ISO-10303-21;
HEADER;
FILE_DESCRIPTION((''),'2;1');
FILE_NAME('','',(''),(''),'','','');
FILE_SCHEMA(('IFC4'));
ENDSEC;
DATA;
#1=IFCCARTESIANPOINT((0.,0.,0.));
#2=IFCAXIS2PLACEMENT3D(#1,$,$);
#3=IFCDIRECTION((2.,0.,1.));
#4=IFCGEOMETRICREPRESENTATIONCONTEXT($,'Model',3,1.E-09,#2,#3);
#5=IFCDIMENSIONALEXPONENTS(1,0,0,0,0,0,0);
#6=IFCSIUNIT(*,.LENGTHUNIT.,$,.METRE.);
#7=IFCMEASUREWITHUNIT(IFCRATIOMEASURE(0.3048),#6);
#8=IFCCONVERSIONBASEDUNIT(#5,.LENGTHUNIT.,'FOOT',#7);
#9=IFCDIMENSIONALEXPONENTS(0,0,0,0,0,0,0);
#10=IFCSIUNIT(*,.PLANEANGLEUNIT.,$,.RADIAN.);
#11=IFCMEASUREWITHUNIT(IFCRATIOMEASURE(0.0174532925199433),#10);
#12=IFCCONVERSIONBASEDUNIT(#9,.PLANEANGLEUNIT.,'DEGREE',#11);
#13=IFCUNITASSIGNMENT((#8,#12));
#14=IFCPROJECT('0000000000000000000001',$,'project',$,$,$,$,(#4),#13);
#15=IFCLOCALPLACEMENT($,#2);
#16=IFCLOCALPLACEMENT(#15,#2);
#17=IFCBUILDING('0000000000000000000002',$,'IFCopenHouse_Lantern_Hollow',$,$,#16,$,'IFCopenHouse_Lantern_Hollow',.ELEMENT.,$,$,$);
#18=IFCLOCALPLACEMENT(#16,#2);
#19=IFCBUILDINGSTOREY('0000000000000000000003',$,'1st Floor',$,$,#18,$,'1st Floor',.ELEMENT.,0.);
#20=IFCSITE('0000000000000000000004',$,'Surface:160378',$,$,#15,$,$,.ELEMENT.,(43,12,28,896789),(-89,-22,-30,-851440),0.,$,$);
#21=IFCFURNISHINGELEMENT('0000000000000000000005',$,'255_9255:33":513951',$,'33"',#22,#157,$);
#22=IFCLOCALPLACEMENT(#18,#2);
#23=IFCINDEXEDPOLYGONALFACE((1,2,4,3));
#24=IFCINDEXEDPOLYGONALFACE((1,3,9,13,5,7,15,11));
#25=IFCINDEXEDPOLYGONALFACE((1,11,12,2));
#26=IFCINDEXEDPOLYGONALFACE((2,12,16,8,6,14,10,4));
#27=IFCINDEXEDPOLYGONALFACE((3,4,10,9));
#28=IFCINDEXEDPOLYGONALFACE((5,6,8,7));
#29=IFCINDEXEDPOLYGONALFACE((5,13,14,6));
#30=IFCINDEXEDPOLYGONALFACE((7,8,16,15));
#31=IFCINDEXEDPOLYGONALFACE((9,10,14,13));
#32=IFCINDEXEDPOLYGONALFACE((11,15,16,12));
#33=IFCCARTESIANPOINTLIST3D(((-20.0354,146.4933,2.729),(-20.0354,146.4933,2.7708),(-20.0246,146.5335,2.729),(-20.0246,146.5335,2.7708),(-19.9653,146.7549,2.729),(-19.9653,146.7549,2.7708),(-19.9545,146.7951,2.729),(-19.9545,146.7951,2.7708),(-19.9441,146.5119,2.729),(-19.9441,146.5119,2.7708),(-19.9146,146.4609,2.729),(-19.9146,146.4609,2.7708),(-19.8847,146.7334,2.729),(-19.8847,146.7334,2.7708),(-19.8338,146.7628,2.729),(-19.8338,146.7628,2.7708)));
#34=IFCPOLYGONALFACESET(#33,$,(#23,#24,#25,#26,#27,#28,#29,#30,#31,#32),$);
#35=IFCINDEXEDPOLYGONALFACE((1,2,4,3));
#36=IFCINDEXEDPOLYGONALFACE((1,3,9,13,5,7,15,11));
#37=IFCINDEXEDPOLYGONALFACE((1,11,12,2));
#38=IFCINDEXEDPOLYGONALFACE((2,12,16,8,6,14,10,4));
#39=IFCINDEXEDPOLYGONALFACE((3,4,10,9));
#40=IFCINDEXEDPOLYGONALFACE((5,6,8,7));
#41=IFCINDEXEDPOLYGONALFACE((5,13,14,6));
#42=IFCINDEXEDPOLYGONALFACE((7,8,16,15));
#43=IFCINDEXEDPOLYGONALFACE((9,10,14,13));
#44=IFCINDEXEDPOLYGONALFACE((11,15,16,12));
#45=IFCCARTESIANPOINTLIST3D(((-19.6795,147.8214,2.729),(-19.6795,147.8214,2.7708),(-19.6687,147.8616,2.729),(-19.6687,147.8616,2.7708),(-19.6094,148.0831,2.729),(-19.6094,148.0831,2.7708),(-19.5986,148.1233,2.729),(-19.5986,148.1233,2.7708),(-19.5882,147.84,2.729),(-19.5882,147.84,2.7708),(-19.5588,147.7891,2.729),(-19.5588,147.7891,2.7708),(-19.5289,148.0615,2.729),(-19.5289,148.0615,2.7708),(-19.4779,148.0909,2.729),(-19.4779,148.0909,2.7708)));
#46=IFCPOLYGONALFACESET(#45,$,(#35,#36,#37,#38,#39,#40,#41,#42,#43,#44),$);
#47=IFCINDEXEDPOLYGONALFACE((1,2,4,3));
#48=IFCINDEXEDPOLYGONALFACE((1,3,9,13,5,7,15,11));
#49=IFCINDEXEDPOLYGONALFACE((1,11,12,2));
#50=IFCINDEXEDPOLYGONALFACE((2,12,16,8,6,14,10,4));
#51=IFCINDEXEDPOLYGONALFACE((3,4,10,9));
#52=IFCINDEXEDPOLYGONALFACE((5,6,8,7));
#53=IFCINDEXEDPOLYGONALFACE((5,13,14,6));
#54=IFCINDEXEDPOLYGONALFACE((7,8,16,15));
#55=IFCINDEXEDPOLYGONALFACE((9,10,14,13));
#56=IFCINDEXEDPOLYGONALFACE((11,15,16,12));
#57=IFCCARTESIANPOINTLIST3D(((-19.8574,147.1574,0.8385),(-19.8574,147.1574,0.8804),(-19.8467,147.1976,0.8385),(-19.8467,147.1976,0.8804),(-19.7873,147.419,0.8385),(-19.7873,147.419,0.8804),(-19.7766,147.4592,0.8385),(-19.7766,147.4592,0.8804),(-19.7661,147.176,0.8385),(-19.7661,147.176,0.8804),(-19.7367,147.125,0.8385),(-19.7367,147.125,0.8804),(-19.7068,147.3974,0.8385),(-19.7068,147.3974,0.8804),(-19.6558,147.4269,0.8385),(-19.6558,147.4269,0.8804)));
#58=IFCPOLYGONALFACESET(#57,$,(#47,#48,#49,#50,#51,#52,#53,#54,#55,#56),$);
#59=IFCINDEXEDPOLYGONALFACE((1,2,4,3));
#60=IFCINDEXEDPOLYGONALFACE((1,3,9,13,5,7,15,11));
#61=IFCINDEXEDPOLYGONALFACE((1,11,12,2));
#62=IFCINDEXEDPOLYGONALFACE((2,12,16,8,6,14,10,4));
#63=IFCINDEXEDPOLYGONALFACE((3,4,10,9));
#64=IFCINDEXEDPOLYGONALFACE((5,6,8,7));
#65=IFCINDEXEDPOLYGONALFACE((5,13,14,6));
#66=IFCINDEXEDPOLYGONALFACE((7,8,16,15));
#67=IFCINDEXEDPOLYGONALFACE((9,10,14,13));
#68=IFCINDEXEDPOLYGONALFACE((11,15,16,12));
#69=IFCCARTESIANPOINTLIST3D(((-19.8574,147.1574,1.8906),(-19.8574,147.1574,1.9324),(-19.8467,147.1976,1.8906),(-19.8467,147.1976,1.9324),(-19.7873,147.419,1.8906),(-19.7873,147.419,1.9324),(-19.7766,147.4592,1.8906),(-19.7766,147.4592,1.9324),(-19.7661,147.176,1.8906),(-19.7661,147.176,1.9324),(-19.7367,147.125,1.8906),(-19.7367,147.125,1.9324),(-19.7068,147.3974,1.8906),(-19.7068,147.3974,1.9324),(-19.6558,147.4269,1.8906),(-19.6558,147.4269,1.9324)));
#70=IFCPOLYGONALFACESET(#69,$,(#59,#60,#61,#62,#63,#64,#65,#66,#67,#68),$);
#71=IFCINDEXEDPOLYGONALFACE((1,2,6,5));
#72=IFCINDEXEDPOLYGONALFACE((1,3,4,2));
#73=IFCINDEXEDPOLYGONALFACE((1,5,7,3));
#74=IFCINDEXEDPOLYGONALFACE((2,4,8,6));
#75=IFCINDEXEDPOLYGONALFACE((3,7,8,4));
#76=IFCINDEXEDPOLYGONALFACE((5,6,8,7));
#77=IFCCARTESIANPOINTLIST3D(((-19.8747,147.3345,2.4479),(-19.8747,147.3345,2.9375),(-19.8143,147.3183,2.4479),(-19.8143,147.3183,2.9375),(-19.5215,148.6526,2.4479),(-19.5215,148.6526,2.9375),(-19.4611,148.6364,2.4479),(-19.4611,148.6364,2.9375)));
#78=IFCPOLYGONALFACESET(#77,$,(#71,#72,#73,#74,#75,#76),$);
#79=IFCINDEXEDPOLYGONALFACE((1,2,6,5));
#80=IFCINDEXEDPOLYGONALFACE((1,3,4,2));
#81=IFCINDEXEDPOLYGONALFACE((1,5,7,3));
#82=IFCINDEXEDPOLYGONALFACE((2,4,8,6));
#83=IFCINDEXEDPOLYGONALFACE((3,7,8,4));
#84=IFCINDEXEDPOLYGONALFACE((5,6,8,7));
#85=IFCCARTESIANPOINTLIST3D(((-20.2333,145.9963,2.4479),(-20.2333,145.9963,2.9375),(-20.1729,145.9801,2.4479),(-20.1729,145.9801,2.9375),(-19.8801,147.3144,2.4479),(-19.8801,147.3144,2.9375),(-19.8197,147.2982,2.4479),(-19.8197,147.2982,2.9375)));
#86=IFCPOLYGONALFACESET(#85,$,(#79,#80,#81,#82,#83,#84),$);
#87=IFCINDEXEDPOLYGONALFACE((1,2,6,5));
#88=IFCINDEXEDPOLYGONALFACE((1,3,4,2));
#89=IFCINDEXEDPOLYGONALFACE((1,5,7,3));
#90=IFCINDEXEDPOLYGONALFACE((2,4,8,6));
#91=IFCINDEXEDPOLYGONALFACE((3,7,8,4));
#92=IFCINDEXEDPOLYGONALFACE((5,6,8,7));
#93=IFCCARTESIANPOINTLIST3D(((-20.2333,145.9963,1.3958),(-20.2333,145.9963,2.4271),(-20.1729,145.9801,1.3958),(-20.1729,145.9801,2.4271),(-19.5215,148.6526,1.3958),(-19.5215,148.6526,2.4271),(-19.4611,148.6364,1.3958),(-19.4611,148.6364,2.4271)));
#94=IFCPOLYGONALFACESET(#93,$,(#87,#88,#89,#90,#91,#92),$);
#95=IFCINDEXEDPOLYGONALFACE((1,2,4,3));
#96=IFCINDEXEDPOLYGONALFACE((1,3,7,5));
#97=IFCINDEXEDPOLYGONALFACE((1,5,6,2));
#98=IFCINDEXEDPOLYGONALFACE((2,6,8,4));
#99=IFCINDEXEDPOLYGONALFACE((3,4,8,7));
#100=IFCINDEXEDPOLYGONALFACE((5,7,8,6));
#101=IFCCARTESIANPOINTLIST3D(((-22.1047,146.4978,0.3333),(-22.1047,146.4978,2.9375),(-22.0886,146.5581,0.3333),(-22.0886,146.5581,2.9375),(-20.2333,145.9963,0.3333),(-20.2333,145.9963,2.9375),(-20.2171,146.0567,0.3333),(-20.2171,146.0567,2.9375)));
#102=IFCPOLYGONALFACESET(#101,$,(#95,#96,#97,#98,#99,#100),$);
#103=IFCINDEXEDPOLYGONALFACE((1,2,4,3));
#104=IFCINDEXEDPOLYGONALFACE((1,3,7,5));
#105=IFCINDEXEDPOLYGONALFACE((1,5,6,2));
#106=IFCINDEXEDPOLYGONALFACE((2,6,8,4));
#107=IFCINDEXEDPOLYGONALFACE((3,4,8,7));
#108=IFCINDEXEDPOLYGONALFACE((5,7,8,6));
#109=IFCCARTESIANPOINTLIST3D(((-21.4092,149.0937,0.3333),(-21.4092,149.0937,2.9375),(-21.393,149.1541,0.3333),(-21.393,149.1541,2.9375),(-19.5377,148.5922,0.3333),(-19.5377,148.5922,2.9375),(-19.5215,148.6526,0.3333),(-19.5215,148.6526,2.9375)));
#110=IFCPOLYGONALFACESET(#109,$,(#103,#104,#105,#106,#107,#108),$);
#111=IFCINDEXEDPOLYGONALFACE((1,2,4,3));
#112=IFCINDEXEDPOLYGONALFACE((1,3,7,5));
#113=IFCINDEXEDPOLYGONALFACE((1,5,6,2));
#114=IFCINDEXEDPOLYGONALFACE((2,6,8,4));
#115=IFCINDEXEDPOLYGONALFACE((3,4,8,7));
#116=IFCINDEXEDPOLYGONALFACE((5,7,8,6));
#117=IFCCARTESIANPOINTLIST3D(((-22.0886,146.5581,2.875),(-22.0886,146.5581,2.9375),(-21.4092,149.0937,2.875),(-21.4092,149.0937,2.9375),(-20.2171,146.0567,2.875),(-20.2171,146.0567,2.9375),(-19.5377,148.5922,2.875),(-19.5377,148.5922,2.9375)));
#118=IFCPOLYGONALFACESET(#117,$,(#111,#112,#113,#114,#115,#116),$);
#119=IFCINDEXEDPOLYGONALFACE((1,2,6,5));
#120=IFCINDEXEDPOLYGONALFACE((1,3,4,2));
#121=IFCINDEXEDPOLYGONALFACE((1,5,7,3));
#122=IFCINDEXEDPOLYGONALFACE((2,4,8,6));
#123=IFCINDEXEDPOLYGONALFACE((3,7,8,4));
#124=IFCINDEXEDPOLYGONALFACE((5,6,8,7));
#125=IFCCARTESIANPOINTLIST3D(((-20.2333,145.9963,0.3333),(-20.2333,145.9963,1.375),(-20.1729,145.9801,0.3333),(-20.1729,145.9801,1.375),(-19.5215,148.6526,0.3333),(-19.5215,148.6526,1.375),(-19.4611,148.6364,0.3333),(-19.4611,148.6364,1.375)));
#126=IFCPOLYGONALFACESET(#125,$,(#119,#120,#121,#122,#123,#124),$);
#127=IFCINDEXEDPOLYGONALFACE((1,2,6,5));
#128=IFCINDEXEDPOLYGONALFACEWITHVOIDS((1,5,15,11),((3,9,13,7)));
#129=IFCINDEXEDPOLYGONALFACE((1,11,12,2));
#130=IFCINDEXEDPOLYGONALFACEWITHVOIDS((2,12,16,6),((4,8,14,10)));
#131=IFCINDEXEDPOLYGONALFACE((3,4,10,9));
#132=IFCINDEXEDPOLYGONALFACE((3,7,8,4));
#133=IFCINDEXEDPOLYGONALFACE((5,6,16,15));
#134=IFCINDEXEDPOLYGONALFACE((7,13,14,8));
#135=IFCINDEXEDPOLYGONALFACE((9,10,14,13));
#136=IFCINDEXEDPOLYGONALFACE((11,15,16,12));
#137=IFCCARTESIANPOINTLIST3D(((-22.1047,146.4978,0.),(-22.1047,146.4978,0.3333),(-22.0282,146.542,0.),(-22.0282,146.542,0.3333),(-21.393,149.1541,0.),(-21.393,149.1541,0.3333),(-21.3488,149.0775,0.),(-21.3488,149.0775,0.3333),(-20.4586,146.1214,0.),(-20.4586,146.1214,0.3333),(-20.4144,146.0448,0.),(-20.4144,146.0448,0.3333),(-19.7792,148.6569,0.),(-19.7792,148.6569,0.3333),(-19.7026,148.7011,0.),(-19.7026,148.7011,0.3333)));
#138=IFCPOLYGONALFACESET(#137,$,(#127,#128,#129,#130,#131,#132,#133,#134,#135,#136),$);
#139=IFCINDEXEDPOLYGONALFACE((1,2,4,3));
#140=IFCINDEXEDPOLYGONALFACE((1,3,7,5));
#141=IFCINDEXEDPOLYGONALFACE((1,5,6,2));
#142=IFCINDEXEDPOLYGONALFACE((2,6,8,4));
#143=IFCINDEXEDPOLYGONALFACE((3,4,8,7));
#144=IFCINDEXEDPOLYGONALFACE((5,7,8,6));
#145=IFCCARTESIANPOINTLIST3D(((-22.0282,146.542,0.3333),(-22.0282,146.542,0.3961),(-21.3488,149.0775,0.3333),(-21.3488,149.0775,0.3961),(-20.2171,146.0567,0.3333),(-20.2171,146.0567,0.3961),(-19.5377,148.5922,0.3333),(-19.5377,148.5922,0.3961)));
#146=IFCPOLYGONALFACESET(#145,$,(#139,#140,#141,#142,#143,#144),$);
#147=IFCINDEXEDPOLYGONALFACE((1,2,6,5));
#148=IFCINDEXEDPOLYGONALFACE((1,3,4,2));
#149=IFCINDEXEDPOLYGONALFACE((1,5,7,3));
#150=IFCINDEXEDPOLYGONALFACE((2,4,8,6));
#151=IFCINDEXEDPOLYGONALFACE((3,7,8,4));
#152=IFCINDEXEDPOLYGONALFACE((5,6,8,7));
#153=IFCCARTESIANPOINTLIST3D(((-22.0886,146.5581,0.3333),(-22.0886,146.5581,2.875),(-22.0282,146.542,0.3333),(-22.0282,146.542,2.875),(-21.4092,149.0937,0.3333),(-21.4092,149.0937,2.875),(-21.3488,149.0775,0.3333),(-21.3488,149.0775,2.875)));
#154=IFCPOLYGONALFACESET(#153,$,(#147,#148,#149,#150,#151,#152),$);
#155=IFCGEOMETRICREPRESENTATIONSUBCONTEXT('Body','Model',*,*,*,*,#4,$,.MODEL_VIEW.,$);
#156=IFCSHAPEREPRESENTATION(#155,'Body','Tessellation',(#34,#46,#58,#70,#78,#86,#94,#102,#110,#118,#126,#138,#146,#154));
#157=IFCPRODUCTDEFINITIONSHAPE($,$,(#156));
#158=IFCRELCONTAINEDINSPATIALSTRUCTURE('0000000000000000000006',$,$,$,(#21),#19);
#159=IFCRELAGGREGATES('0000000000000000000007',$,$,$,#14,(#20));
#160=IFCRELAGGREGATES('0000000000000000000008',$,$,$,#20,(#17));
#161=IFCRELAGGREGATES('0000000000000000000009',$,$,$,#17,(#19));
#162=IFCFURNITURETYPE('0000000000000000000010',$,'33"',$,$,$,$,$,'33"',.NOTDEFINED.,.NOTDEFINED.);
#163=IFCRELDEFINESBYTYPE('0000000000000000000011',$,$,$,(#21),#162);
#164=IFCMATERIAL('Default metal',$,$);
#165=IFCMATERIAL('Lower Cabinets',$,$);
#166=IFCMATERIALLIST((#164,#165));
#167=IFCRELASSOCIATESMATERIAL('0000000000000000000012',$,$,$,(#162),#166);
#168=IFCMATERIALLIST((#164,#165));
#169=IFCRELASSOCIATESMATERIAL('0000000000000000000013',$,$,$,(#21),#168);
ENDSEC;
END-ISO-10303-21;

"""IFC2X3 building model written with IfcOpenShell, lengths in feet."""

from ifc_helpers import new_model, entity, si_unit, converted_unit, direction, frame, frame_2d, origin, origin_2d_with_axis, place, context, subcontext, project, spatial, polyline, rectangle, outline, extrude, source, transform, mapped, material, material_list, type_object, type_shapes, element, save


model = new_model("IFC2X3")

# Units and contexts
model_context = context("Model", 3, precision=1e-09, world=origin(), true_north=direction((2.0, 0.0, 1.0)))
body_context = subcontext(model_context, "Body", "Model", "MODEL_VIEW")
ifc_project = project(units=[converted_unit("LENGTHUNIT", "FOOT", entity("IfcRatioMeasure", 0.3048), si_unit("LENGTHUNIT", "METRE"), dimensions=[1, 0, 0, 0, 0, 0, 0]), converted_unit("PLANEANGLEUNIT", "DEGREE", entity("IfcRatioMeasure", 0.0174532925199433), si_unit("PLANEANGLEUNIT", "RADIAN"), dimensions=[0, 0, 0, 0, 0, 0, 0])], contexts=[model_context])

# Site, building, storey
site_placement = place(None, origin())
site = spatial("IfcSite", under=ifc_project, at=site_placement, Name="Surface:160378", CompositionType="ELEMENT", RefLatitude=(43, 12, 28, 896789), RefLongitude=(-89, -22, -30, -851440), RefElevation=0.0)
building_placement = place(site_placement, origin())
building = spatial("IfcBuilding", under=site, at=building_placement, Name="IFCopenHouse_Lantern_Hollow", LongName="IFCopenHouse_Lantern_Hollow", CompositionType="ELEMENT")
storey_placement = place(building_placement, origin())
storey = spatial("IfcBuildingStorey", under=building, at=storey_placement, Name="1st Floor", LongName="1st Floor", CompositionType="ELEMENT", Elevation=0.0)

# Furnishing element
ifc_material_1 = material(Name="Default metal")
ifc_material_2 = material(Name="Lower Cabinets")
ifc_material_list_1 = material_list([ifc_material_1, ifc_material_2])
furniture_type_1 = type_object("IfcFurnitureType", Name="33\"", ElementType="33\"", AssemblyPlace="NOTDEFINED", material=ifc_material_list_1)
shared_shape_1 = source(origin(), body_context, "Body", "SweptSolid", [
    extrude(outline(polyline([(-0.0521, -0.1562), (0.0729, -0.1562), (0.0729, 0.1562), (-0.0521, 0.1562), (-0.0521, 0.1146), (0.0313, 0.1146), (0.0313, -0.1146), (-0.0521, -0.1146), (-0.0521, -0.1562)])), frame((-0.626, -2.0521, 2.729), z_axis=(0.0, 0.0, 1.0), x_axis=(0.0, -1.0, 0.0)), (0.0, 0.0, 1.0), 0.0418),
    extrude(outline(polyline([(-0.0521, -0.1562), (0.0729, -0.1562), (0.0729, 0.1562), (-0.0521, 0.1562), (-0.0521, 0.1146), (0.0313, 0.1146), (0.0313, -0.1146), (-0.0521, -0.1146), (-0.0521, -0.1562)])), frame((0.749, -2.0521, 2.729), z_axis=(0.0, 0.0, 1.0), x_axis=(0.0, -1.0, 0.0)), (0.0, 0.0, 1.0), 0.0418),
    extrude(outline(polyline([(-0.0521, -0.1562), (0.0729, -0.1562), (0.0729, 0.1562), (-0.0521, 0.1562), (-0.0521, 0.1146), (0.0313, 0.1146), (0.0313, -0.1146), (-0.0521, -0.1146), (-0.0521, -0.1562)])), frame((0.0615, -2.0521, 0.8385), z_axis=(0.0, 0.0, 1.0), x_axis=(0.0, -1.0, 0.0)), (0.0, 0.0, 1.0), 0.0418),
    extrude(outline(polyline([(-0.0521, -0.1562), (0.0729, -0.1562), (0.0729, 0.1562), (-0.0521, 0.1562), (-0.0521, 0.1146), (0.0313, 0.1146), (0.0313, -0.1146), (-0.0521, -0.1146), (-0.0521, -0.1562)])), frame((0.0615, -2.0521, 1.8906), z_axis=(0.0, 0.0, 1.0), x_axis=(0.0, -1.0, 0.0)), (0.0, 0.0, 1.0), 0.0418),
    extrude(rectangle(XDim=0.0625, YDim=1.3646, at=frame_2d((0.0, 0.0), x_axis=(1.0, 0.0))), frame((0.7542, -1.9688, 2.4479), z_axis=(0.0, 0.0, 1.0), x_axis=(0.0, 1.0, 0.0)), (0.0, 0.0, 1.0), 0.4896),
    extrude(rectangle(XDim=0.0625, YDim=1.3646, at=origin_2d_with_axis()), frame((-0.6312, -1.9688, 2.4479), z_axis=(0.0, 0.0, 1.0), x_axis=(0.0, 1.0, 0.0)), (0.0, 0.0, 1.0), 0.4896),
    extrude(rectangle(XDim=0.0625, YDim=2.75, at=frame_2d((0.0, 0.0), x_axis=(1.0, 0.0))), frame((0.0615, -1.9688, 1.3958), z_axis=(0.0, 0.0, 1.0), x_axis=(0.0, 1.0, 0.0)), (0.0, 0.0, 1.0), 1.0313),
    extrude(rectangle(XDim=0.0625, YDim=1.9375, at=frame_2d((0.0, 0.0), x_axis=(1.0, 0.0))), frame((-1.2823, -0.9687, 0.3333)), (0.0, 0.0, 1.0), 2.6042),
    extrude(rectangle(XDim=0.0625, YDim=1.9375, at=frame_2d((0.0, 0.0), x_axis=(1.0, 0.0))), frame((1.4052, -0.9687, 0.3333)), (0.0, 0.0, 1.0), 2.6042),
    extrude(rectangle(XDim=2.625, YDim=1.9375, at=origin_2d_with_axis()), frame((0.0615, -0.9688, 2.875), z_axis=(0.0, 0.0, 1.0), x_axis=(-1.0, 0.0, 0.0)), (0.0, 0.0, 1.0), 0.0625),
    extrude(rectangle(XDim=0.0625, YDim=2.75, at=frame_2d((0.0, 0.0), x_axis=(1.0, 0.0))), frame((0.0615, -1.9688, 0.3333), z_axis=(0.0, 0.0, 1.0), x_axis=(0.0, 1.0, 0.0)), (0.0, 0.0, 1.0), 1.0417),
    extrude(outline(polyline([(-1.375, -0.875), (1.375, -0.875), (1.375, 0.875), (-1.375, 0.875), (-1.375, -0.875)]), holes=[polyline([(-1.3125, -0.8125), (-1.3125, 0.8125), (1.3125, 0.8125), (1.3125, -0.8125), (-1.3125, -0.8125)])]), frame((0.0615, -0.875, 0.0)), (0.0, 0.0, 1.0), 0.3333),
    extrude(rectangle(XDim=2.625, YDim=1.875, at=frame_2d((0.0, 0.0), x_axis=(1.0, 0.0))), frame((0.0615, -1.0, 0.3333), z_axis=(0.0, 0.0, 1.0), x_axis=(-1.0, 0.0, 0.0)), (0.0, 0.0, 1.0), 0.0627),
    extrude(rectangle(XDim=0.0625, YDim=2.625, at=origin_2d_with_axis()), frame((0.0615, -0.0312, 0.3333), z_axis=(0.0, 0.0, 1.0), x_axis=(0.0, 1.0, 0.0)), (0.0, 0.0, 1.0), 2.5417),
])
type_shapes(furniture_type_1, [shared_shape_1])
ifc_material_list_2 = material_list([ifc_material_1, ifc_material_2])
furnishing_1_placement = place(storey_placement, frame((-21.7648, 147.7665, 0.0), z_axis=(0.0, 0.0, 1.0), x_axis=(0.258819, 0.965926, 0.0)))
element("IfcFurnishingElement", 1, at=furnishing_1_placement, inside=storey, type_object=furniture_type_1, material=ifc_material_list_2, Name="255_9255:33\":513951", ObjectType="33\"", context=body_context, shape_type="MappedRepresentation", body=[
    mapped(shared_shape_1, transform((0.0, 0.0, 0.0), scale=1.0)),
])

save(model, "model.ifc")
